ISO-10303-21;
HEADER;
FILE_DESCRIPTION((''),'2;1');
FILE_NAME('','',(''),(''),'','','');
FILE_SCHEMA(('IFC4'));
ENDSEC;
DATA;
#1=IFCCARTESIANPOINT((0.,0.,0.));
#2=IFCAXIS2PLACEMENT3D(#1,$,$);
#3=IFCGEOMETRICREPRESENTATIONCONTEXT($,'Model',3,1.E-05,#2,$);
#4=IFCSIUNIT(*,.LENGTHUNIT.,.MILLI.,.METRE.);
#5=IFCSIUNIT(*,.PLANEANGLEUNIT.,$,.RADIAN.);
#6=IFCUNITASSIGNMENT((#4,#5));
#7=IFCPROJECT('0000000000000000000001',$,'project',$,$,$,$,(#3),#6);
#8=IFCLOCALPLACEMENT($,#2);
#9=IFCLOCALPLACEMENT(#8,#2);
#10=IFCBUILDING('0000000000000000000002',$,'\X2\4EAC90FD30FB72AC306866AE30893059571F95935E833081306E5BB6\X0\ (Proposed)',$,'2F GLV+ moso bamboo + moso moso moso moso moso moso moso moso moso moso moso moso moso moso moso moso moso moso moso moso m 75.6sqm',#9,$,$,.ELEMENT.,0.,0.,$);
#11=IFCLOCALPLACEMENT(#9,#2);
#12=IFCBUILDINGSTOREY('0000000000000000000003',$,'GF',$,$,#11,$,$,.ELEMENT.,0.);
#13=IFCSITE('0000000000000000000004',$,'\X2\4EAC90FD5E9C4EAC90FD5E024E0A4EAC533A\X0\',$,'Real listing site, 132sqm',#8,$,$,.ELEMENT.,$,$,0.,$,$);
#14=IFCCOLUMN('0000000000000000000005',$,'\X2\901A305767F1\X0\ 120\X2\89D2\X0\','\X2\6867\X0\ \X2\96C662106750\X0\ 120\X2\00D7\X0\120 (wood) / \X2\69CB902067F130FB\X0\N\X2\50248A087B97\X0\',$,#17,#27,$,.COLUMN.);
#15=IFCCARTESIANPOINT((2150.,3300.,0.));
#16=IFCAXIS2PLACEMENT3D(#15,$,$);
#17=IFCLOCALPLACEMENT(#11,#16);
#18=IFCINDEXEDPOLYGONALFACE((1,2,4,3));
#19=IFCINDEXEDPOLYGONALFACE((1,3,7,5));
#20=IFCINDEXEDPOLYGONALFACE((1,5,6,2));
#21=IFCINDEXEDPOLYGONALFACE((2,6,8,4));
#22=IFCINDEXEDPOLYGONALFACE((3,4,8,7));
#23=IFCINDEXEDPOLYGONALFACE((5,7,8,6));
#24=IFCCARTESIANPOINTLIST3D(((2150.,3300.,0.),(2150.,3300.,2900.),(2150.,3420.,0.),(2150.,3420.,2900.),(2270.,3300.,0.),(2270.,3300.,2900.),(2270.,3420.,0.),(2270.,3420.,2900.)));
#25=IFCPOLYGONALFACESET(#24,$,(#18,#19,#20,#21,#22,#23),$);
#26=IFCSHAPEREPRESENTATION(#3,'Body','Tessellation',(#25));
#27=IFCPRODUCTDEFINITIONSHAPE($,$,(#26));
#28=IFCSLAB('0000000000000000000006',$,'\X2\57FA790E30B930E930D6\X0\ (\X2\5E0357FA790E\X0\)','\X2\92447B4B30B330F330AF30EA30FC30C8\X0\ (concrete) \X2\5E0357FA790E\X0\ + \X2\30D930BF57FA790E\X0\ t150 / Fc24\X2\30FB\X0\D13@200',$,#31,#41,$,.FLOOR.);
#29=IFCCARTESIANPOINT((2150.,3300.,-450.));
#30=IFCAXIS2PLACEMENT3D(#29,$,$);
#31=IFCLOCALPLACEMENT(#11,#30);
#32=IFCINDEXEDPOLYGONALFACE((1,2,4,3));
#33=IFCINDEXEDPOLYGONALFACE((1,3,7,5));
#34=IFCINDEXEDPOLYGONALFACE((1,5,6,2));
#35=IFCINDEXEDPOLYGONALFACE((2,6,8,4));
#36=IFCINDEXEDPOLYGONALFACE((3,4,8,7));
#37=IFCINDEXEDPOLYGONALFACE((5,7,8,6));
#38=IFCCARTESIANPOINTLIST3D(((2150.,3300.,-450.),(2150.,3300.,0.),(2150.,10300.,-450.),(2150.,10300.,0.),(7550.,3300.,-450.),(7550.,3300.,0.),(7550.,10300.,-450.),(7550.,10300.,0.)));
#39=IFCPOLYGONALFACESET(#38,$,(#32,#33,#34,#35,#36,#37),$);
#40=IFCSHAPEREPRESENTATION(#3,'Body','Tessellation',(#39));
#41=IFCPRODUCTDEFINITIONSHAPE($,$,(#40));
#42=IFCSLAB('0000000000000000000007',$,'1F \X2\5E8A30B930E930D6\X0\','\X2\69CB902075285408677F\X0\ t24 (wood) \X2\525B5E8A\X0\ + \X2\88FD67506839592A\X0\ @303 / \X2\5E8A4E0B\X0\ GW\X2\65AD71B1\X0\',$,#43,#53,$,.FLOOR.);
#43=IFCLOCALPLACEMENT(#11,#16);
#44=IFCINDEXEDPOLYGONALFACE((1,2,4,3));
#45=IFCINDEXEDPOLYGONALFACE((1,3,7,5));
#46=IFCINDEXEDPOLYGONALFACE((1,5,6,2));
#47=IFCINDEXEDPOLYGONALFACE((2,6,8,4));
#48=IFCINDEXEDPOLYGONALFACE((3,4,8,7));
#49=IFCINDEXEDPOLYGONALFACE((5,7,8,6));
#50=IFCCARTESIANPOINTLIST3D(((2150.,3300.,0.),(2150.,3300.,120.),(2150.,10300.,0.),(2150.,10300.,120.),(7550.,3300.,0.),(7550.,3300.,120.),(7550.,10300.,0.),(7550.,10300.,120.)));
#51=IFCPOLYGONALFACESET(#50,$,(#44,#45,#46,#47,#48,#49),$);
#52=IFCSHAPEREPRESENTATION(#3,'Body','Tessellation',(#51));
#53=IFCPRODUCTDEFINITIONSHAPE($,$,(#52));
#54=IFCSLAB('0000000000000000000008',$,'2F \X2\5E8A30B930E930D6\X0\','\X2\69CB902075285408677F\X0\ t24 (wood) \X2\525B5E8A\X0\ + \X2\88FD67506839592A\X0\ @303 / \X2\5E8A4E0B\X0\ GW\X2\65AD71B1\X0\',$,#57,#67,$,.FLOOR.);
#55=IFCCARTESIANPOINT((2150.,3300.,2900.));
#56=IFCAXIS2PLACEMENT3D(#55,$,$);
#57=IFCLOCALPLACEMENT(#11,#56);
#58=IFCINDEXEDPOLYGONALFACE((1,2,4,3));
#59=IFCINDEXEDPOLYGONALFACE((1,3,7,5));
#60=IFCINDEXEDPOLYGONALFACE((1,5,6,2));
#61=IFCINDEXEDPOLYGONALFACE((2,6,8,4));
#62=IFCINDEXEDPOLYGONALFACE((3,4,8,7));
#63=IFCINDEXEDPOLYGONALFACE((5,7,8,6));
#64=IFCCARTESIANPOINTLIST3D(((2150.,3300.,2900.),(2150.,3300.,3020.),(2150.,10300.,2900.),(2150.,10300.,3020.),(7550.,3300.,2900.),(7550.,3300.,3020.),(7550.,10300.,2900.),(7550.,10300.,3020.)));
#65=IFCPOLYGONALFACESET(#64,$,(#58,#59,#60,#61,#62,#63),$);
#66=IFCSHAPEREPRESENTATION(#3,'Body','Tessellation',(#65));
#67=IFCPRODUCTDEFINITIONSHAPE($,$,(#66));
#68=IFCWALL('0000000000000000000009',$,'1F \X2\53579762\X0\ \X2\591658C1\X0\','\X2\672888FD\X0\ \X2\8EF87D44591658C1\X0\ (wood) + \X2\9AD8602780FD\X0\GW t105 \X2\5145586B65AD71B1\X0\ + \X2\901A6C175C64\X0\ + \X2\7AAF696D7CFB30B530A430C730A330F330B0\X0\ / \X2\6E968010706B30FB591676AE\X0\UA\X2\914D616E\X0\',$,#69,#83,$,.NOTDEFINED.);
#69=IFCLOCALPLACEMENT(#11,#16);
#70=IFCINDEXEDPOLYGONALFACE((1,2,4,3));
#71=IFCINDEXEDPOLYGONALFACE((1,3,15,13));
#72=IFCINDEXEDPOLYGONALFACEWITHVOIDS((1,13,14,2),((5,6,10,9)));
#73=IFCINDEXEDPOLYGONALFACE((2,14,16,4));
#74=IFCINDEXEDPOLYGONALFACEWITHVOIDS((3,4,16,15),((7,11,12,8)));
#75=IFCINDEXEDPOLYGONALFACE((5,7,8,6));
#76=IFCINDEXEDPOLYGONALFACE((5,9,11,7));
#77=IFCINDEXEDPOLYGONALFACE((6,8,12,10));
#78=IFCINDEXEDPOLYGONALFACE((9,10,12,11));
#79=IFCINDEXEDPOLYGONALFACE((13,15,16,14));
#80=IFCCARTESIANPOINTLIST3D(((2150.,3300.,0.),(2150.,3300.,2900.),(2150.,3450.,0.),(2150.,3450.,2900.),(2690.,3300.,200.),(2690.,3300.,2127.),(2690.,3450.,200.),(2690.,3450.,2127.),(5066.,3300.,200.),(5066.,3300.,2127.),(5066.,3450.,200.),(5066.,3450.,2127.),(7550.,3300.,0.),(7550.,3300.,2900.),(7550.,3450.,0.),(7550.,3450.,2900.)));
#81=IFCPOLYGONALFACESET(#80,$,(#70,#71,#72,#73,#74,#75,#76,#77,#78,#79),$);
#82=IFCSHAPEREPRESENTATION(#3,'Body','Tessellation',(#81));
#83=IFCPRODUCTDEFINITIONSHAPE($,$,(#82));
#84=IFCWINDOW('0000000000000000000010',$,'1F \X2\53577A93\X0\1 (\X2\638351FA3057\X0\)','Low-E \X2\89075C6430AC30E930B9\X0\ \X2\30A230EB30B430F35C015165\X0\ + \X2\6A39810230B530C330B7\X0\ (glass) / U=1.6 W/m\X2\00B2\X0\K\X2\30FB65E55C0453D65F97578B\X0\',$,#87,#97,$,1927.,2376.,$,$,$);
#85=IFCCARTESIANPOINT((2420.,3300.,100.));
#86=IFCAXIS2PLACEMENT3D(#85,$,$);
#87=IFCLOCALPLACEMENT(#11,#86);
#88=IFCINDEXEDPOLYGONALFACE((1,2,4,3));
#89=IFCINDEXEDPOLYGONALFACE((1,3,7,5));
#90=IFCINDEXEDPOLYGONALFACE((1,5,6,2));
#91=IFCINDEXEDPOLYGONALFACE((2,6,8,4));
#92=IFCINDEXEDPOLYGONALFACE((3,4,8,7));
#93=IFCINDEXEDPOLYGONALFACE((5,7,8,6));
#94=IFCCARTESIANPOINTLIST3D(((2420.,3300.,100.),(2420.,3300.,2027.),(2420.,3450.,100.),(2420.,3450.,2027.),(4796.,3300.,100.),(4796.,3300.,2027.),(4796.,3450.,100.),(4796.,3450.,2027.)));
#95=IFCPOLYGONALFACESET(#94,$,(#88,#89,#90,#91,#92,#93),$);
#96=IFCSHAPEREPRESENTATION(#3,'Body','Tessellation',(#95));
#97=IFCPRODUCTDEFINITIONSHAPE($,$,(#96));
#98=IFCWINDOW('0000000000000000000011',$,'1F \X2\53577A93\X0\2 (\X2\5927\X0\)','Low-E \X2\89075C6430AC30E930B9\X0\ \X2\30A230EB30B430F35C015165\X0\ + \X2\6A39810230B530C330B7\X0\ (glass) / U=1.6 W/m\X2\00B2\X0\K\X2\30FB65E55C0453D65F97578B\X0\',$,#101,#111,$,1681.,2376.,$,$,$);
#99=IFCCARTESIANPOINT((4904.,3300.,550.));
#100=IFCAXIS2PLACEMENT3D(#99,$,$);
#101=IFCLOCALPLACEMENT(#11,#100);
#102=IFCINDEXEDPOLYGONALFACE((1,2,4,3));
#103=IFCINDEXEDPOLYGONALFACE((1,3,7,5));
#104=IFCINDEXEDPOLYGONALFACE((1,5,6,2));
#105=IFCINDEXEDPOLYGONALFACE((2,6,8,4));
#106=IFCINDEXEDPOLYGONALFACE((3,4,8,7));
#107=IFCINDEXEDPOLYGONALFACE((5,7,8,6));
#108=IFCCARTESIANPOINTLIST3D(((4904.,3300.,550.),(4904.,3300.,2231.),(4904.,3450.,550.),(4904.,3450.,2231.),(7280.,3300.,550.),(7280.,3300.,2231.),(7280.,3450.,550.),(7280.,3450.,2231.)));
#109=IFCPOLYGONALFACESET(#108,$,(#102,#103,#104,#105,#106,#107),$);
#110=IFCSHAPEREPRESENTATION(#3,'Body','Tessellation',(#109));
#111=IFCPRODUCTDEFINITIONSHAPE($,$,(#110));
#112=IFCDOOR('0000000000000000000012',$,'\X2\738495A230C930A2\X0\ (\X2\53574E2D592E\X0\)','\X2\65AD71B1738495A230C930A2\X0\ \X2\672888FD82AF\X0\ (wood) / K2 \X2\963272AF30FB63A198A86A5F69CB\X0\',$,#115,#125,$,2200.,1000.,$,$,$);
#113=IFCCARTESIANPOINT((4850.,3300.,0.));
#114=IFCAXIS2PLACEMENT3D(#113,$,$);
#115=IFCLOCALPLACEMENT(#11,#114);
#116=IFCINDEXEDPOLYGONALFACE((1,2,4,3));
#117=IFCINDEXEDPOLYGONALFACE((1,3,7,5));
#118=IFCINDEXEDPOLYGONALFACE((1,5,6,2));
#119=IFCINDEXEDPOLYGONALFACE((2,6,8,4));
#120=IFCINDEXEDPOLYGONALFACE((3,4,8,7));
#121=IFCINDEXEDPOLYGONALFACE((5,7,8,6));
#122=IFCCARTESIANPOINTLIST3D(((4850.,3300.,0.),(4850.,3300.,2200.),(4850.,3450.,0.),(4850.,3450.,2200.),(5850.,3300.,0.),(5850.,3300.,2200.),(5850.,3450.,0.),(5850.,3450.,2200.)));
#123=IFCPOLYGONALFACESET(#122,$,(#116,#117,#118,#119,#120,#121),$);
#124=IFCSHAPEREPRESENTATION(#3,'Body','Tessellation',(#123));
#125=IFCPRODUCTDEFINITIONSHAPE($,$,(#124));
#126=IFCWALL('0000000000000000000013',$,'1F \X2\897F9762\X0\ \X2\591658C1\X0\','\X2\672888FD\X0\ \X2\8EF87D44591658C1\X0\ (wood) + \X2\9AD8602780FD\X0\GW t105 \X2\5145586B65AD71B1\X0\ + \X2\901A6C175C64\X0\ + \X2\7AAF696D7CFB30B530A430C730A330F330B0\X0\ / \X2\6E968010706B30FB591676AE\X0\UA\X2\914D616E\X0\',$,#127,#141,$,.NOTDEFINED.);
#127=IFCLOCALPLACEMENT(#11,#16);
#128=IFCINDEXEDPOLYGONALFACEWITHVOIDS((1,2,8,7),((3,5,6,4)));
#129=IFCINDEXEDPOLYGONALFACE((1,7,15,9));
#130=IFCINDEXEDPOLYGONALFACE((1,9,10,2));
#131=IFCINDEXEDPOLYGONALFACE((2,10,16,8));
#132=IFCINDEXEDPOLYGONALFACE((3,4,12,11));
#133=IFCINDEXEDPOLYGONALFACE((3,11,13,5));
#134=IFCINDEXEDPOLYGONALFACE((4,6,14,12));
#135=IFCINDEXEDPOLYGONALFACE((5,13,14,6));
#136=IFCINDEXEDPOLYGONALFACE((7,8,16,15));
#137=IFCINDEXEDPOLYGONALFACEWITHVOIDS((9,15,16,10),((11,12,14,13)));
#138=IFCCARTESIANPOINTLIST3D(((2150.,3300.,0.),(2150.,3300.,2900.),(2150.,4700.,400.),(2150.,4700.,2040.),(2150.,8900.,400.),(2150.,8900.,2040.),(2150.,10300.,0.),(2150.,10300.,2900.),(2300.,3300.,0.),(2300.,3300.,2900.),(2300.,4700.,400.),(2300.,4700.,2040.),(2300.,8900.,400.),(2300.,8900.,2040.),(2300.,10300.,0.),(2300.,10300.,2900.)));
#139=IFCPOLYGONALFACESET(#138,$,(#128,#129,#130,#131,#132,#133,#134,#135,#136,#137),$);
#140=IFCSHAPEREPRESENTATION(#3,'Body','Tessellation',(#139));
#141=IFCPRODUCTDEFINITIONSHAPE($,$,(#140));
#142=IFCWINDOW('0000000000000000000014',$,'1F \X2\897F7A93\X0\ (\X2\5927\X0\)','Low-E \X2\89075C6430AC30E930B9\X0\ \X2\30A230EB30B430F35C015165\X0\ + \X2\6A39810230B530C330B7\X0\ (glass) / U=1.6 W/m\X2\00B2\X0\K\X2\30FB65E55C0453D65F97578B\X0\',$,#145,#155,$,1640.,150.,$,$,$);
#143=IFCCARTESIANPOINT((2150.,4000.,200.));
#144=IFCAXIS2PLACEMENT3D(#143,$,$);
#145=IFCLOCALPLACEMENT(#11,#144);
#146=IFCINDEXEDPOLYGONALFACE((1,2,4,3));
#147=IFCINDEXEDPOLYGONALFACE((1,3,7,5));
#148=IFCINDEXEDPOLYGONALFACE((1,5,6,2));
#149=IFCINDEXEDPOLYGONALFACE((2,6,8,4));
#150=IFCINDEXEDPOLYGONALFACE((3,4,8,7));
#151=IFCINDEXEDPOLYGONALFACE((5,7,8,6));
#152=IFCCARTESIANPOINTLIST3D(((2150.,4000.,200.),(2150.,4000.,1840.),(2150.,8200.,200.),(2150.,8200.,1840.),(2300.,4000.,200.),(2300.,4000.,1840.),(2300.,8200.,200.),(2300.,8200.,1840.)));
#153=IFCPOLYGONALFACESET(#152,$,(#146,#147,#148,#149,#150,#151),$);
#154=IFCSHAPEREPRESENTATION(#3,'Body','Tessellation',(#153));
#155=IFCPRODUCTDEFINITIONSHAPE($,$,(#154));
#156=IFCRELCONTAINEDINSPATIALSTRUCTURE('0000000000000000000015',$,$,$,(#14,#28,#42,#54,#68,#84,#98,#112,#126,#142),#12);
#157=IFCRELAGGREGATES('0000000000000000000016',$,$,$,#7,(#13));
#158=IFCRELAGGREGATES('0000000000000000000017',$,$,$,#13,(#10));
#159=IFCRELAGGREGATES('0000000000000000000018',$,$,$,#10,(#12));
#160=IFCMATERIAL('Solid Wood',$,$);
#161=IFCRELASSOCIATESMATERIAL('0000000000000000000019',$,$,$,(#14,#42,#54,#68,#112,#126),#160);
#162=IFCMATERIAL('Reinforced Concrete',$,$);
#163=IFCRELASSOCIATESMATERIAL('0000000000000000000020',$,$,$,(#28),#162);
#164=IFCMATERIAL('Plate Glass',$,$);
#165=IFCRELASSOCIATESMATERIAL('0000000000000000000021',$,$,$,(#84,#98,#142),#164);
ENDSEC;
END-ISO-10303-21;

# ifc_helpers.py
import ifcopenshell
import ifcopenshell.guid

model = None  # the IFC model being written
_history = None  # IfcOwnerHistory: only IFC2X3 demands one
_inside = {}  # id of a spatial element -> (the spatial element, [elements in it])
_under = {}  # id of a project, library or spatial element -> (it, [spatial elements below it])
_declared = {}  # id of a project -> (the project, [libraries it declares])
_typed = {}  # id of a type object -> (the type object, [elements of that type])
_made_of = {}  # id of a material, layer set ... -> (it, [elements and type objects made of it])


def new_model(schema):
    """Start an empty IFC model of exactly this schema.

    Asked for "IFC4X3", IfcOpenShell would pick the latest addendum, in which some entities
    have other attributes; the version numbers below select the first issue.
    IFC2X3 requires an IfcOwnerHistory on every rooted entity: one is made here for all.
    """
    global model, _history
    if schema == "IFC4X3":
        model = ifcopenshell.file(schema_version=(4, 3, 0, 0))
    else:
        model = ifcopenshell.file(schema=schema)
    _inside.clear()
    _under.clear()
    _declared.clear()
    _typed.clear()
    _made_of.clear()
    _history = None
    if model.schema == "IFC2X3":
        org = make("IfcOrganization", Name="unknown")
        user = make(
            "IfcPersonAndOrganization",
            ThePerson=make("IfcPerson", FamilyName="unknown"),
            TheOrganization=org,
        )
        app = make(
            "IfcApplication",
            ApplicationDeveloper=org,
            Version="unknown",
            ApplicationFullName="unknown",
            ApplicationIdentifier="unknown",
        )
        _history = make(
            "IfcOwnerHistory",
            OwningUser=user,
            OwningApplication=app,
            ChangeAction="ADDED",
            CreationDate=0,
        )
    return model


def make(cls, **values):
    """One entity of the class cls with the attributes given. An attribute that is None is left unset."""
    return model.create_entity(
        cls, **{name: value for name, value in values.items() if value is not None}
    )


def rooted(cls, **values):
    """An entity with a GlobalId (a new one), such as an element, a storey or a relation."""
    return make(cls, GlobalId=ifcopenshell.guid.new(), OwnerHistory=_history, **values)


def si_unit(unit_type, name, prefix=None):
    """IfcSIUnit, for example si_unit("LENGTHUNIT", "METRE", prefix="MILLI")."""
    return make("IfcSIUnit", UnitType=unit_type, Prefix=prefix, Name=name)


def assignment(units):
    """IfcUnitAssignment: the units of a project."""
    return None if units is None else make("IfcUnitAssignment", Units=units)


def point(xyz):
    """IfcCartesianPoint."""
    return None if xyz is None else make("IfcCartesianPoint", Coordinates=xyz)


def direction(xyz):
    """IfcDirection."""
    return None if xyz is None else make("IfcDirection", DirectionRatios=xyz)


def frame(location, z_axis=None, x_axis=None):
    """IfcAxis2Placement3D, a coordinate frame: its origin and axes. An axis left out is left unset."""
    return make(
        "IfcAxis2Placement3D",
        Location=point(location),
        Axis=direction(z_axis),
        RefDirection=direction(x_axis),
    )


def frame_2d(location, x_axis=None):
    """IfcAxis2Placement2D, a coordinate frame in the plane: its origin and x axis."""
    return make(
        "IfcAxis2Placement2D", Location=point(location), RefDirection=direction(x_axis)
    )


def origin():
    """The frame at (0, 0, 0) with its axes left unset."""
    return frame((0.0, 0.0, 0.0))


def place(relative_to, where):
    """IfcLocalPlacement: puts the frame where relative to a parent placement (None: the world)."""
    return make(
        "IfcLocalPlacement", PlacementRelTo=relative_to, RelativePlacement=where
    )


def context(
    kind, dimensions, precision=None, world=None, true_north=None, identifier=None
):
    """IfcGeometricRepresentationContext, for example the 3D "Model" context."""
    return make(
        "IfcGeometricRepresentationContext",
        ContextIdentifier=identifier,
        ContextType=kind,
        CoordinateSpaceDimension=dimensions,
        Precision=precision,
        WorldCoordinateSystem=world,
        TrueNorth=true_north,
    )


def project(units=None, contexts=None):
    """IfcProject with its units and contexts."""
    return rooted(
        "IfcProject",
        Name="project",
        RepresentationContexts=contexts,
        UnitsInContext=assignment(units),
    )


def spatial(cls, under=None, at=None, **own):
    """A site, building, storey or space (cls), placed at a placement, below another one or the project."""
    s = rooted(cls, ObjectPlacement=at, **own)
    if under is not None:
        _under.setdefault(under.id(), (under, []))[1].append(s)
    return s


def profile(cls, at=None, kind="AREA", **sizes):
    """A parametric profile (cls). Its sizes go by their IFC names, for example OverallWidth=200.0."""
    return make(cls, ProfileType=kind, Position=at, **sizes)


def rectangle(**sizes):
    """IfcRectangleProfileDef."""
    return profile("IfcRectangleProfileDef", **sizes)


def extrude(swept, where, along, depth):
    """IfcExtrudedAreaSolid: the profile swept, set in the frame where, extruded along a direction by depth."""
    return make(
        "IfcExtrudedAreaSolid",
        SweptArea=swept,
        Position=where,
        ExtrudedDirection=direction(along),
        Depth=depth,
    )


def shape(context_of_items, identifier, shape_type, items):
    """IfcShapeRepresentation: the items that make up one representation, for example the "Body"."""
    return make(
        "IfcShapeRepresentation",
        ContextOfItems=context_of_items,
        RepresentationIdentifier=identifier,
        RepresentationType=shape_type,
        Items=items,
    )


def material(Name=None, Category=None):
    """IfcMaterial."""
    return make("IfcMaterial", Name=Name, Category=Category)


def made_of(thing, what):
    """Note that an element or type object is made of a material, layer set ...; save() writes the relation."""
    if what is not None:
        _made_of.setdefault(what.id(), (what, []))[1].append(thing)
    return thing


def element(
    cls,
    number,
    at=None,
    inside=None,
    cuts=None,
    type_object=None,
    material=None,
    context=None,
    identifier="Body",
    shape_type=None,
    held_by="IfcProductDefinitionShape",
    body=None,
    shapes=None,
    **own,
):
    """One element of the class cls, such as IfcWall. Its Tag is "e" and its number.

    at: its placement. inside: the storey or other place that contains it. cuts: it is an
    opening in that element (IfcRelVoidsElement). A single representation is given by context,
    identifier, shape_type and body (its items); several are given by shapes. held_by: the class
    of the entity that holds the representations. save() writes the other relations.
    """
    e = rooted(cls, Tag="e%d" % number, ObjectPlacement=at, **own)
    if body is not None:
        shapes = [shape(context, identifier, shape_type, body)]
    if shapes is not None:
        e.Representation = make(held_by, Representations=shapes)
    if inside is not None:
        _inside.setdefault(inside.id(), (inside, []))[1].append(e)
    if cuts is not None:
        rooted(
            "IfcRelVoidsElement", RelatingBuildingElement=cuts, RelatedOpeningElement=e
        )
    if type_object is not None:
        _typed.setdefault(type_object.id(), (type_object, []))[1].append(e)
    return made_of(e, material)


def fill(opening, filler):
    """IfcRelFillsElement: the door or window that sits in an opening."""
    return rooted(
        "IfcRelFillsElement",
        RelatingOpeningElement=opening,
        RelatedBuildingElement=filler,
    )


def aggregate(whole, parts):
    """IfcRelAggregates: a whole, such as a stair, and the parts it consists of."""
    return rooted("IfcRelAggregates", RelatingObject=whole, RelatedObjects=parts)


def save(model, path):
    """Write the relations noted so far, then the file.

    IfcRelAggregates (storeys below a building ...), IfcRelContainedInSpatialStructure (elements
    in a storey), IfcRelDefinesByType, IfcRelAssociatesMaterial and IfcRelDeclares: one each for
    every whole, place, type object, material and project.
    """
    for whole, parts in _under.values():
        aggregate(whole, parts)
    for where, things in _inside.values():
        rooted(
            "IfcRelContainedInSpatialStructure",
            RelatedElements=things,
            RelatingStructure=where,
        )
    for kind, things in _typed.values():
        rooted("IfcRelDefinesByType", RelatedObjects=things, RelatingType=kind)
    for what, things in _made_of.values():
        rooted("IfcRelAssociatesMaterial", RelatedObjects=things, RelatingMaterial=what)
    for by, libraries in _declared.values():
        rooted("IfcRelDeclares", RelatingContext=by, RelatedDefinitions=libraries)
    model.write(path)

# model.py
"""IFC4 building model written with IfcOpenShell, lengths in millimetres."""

from ifc_helpers import new_model, si_unit, frame, frame_2d, origin, place, context, project, spatial, rectangle, extrude, material, element, fill, save


model = new_model("IFC4")

# Units and contexts
model_context = context("Model", 3, precision=1e-05, world=origin())
ifc_project = project(units=[si_unit("LENGTHUNIT", "METRE", prefix="MILLI"), si_unit("PLANEANGLEUNIT", "RADIAN")], contexts=[model_context])

# Site, building, storey
site_placement = place(None, origin())
site = spatial("IfcSite", under=ifc_project, at=site_placement, Name="京都府京都市上京区", ObjectType="Real listing site, 132sqm", CompositionType="ELEMENT", RefElevation=0.0)
building_placement = place(site_placement, origin())
building = spatial("IfcBuilding", under=site, at=building_placement, Name="京都・犬と暮らす土間広めの家 (Proposed)", ObjectType="2F GLV+ moso bamboo + moso moso moso moso moso moso moso moso moso moso moso moso moso moso moso moso moso moso moso moso m 75.6sqm", CompositionType="ELEMENT", ElevationOfRefHeight=0.0, ElevationOfTerrain=0.0)
storey_placement = place(building_placement, origin())
storey = spatial("IfcBuildingStorey", under=building, at=storey_placement, Name="GF", CompositionType="ELEMENT", Elevation=0.0)

# Column
ifc_material_1 = material(Name="Solid Wood")
column_placement = place(storey_placement, frame((2150.0, 3300.0, 0.0)))
element("IfcColumn", 1, at=column_placement, inside=storey, material=ifc_material_1, Name="通し柱 120角", Description="桧 集成材 120×120 (wood) / 構造柱・N値計算", PredefinedType="COLUMN", context=model_context, shape_type="SweptSolid", body=[
    extrude(rectangle(XDim=120.0, YDim=120.0, at=frame_2d((60.0, 60.0))), frame((2150.0, 3300.0, 0.0)), (0.0, 0.0, 1.0), 2900.0),
])

# Slabs
ifc_material_2 = material(Name="Reinforced Concrete")
slab_1_placement = place(storey_placement, frame((2150.0, 3300.0, -450.0)))
element("IfcSlab", 2, at=slab_1_placement, inside=storey, material=ifc_material_2, Name="基礎スラブ (布基礎)", Description="鉄筋コンクリート (concrete) 布基礎 + ベタ基礎 t150 / Fc24・D13@200", PredefinedType="FLOOR", context=model_context, shape_type="SweptSolid", body=[
    extrude(rectangle(XDim=5400.0, YDim=7000.0, at=frame_2d((2700.0, 3500.0))), frame((2150.0, 3300.0, -450.0)), (0.0, 0.0, 1.0), 450.0),
])
slab_2_placement = place(storey_placement, frame((2150.0, 3300.0, 0.0)))
element("IfcSlab", 3, at=slab_2_placement, inside=storey, material=ifc_material_1, Name="1F 床スラブ", Description="構造用合板 t24 (wood) 剛床 + 製材根太 @303 / 床下 GW断熱", PredefinedType="FLOOR", context=model_context, shape_type="SweptSolid", body=[
    extrude(rectangle(XDim=5400.0, YDim=7000.0, at=frame_2d((2700.0, 3500.0))), frame((2150.0, 3300.0, 0.0)), (0.0, 0.0, 1.0), 120.0),
])
slab_3_placement = place(storey_placement, frame((2150.0, 3300.0, 2900.0)))
element("IfcSlab", 4, at=slab_3_placement, inside=storey, material=ifc_material_1, Name="2F 床スラブ", Description="構造用合板 t24 (wood) 剛床 + 製材根太 @303 / 床下 GW断熱", PredefinedType="FLOOR", context=model_context, shape_type="SweptSolid", body=[
    extrude(rectangle(XDim=5400.0, YDim=7000.0, at=frame_2d((2700.0, 3500.0))), frame((2150.0, 3300.0, 2900.0)), (0.0, 0.0, 1.0), 120.0),
])

# Wall, openings, windows, door
wall_1_placement = place(storey_placement, frame((2150.0, 3300.0, 0.0)))
wall_1 = element("IfcWall", 5, at=wall_1_placement, inside=storey, material=ifc_material_1, Name="1F 南面 外壁", Description="木製 軸組外壁 (wood) + 高性能GW t105 充填断熱 + 通気層 + 窯業系サイディング / 準耐火・外皮UA配慮", PredefinedType="NOTDEFINED", context=model_context, shape_type="SweptSolid", body=[
    extrude(rectangle(XDim=5400.0, YDim=150.0, at=frame_2d((2700.0, 75.0))), frame((2150.0, 3300.0, 0.0)), (0.0, 0.0, 1.0), 2900.0),
])
opening_1_placement = place(storey_placement, frame((2420.0, 3300.0, 100.0)))
opening_1 = element("IfcOpeningElement", 6, at=opening_1_placement, cuts=wall_1, PredefinedType="NOTDEFINED", context=model_context, shape_type="SweptSolid", body=[
    extrude(rectangle(XDim=2376.0, YDim=150.0, at=frame_2d((1188.0, 75.0))), frame((2420.0, 3300.0, 100.0)), (0.0, 0.0, 1.0), 1927.0),
])
opening_2_placement = place(storey_placement, frame((4904.0, 3300.0, 550.0)))
opening_2 = element("IfcOpeningElement", 7, at=opening_2_placement, cuts=wall_1, PredefinedType="NOTDEFINED", context=model_context, shape_type="SweptSolid", body=[
    extrude(rectangle(XDim=2376.0, YDim=150.0, at=frame_2d((1188.0, 75.0))), frame((4904.0, 3300.0, 550.0)), (0.0, 0.0, 1.0), 1681.0),
])
opening_3_placement = place(storey_placement, frame((4850.0, 3300.0, 0.0)))
opening_3 = element("IfcOpeningElement", 8, at=opening_3_placement, cuts=wall_1, PredefinedType="NOTDEFINED", context=model_context, shape_type="SweptSolid", body=[
    extrude(rectangle(XDim=1000.0, YDim=150.0, at=frame_2d((500.0, 75.0))), frame((4850.0, 3300.0, 0.0)), (0.0, 0.0, 1.0), 2200.0),
])
ifc_material_3 = material(Name="Plate Glass")
window_1_placement = place(storey_placement, frame((2420.0, 3300.0, 100.0)))
window_1 = element("IfcWindow", 9, at=window_1_placement, inside=storey, material=ifc_material_3, Name="1F 南窓1 (掃出し)", Description="Low-E 複層ガラス アルゴン封入 + 樹脂サッシ (glass) / U=1.6 W/m²K・日射取得型", OverallHeight=1927.0, OverallWidth=2376.0, context=model_context, shape_type="SweptSolid", body=[
    extrude(rectangle(XDim=2376.0, YDim=150.0, at=frame_2d((1188.0, 75.0))), frame((2420.0, 3300.0, 100.0)), (0.0, 0.0, 1.0), 1927.0),
])
fill(opening_1, window_1)
window_2_placement = place(storey_placement, frame((4904.0, 3300.0, 550.0)))
window_2 = element("IfcWindow", 10, at=window_2_placement, inside=storey, material=ifc_material_3, Name="1F 南窓2 (大)", Description="Low-E 複層ガラス アルゴン封入 + 樹脂サッシ (glass) / U=1.6 W/m²K・日射取得型", OverallHeight=1681.0, OverallWidth=2376.0, context=model_context, shape_type="SweptSolid", body=[
    extrude(rectangle(XDim=2376.0, YDim=150.0, at=frame_2d((1188.0, 75.0))), frame((4904.0, 3300.0, 550.0)), (0.0, 0.0, 1.0), 1681.0),
])
fill(opening_2, window_2)
door_placement = place(storey_placement, frame((4850.0, 3300.0, 0.0)))
door = element("IfcDoor", 11, at=door_placement, inside=storey, material=ifc_material_1, Name="玄関ドア (南中央)", Description="断熱玄関ドア 木製芯 (wood) / K2 防犯・採風機構", OverallHeight=2200.0, OverallWidth=1000.0, context=model_context, shape_type="SweptSolid", body=[
    extrude(rectangle(XDim=1000.0, YDim=150.0, at=frame_2d((500.0, 75.0))), frame((4850.0, 3300.0, 0.0)), (0.0, 0.0, 1.0), 2200.0),
])
fill(opening_3, door)

# Wall, opening, window
wall_2_placement = place(storey_placement, frame((2150.0, 3300.0, 0.0)))
wall_2 = element("IfcWall", 12, at=wall_2_placement, inside=storey, material=ifc_material_1, Name="1F 西面 外壁", Description="木製 軸組外壁 (wood) + 高性能GW t105 充填断熱 + 通気層 + 窯業系サイディング / 準耐火・外皮UA配慮", PredefinedType="NOTDEFINED", context=model_context, shape_type="SweptSolid", body=[
    extrude(rectangle(XDim=150.0, YDim=7000.0, at=frame_2d((75.0, 3500.0))), frame((2150.0, 3300.0, 0.0)), (0.0, 0.0, 1.0), 2900.0),
])
opening_4_placement = place(storey_placement, frame((2150.0, 4000.0, 200.0)))
opening_4 = element("IfcOpeningElement", 13, at=opening_4_placement, cuts=wall_2, PredefinedType="NOTDEFINED", context=model_context, shape_type="SweptSolid", body=[
    extrude(rectangle(XDim=150.0, YDim=4200.0, at=frame_2d((75.0, 2100.0))), frame((2150.0, 4000.0, 200.0)), (0.0, 0.0, 1.0), 1640.0),
])
window_3_placement = place(storey_placement, frame((2150.0, 4000.0, 200.0)))
window_3 = element("IfcWindow", 14, at=window_3_placement, inside=storey, material=ifc_material_3, Name="1F 西窓 (大)", Description="Low-E 複層ガラス アルゴン封入 + 樹脂サッシ (glass) / U=1.6 W/m²K・日射取得型", OverallHeight=1640.0, OverallWidth=150.0, context=model_context, shape_type="SweptSolid", body=[
    extrude(rectangle(XDim=150.0, YDim=4200.0, at=frame_2d((75.0, 2100.0))), frame((2150.0, 4000.0, 200.0)), (0.0, 0.0, 1.0), 1640.0),
])
fill(opening_4, window_3)

save(model, "model.ifc")
